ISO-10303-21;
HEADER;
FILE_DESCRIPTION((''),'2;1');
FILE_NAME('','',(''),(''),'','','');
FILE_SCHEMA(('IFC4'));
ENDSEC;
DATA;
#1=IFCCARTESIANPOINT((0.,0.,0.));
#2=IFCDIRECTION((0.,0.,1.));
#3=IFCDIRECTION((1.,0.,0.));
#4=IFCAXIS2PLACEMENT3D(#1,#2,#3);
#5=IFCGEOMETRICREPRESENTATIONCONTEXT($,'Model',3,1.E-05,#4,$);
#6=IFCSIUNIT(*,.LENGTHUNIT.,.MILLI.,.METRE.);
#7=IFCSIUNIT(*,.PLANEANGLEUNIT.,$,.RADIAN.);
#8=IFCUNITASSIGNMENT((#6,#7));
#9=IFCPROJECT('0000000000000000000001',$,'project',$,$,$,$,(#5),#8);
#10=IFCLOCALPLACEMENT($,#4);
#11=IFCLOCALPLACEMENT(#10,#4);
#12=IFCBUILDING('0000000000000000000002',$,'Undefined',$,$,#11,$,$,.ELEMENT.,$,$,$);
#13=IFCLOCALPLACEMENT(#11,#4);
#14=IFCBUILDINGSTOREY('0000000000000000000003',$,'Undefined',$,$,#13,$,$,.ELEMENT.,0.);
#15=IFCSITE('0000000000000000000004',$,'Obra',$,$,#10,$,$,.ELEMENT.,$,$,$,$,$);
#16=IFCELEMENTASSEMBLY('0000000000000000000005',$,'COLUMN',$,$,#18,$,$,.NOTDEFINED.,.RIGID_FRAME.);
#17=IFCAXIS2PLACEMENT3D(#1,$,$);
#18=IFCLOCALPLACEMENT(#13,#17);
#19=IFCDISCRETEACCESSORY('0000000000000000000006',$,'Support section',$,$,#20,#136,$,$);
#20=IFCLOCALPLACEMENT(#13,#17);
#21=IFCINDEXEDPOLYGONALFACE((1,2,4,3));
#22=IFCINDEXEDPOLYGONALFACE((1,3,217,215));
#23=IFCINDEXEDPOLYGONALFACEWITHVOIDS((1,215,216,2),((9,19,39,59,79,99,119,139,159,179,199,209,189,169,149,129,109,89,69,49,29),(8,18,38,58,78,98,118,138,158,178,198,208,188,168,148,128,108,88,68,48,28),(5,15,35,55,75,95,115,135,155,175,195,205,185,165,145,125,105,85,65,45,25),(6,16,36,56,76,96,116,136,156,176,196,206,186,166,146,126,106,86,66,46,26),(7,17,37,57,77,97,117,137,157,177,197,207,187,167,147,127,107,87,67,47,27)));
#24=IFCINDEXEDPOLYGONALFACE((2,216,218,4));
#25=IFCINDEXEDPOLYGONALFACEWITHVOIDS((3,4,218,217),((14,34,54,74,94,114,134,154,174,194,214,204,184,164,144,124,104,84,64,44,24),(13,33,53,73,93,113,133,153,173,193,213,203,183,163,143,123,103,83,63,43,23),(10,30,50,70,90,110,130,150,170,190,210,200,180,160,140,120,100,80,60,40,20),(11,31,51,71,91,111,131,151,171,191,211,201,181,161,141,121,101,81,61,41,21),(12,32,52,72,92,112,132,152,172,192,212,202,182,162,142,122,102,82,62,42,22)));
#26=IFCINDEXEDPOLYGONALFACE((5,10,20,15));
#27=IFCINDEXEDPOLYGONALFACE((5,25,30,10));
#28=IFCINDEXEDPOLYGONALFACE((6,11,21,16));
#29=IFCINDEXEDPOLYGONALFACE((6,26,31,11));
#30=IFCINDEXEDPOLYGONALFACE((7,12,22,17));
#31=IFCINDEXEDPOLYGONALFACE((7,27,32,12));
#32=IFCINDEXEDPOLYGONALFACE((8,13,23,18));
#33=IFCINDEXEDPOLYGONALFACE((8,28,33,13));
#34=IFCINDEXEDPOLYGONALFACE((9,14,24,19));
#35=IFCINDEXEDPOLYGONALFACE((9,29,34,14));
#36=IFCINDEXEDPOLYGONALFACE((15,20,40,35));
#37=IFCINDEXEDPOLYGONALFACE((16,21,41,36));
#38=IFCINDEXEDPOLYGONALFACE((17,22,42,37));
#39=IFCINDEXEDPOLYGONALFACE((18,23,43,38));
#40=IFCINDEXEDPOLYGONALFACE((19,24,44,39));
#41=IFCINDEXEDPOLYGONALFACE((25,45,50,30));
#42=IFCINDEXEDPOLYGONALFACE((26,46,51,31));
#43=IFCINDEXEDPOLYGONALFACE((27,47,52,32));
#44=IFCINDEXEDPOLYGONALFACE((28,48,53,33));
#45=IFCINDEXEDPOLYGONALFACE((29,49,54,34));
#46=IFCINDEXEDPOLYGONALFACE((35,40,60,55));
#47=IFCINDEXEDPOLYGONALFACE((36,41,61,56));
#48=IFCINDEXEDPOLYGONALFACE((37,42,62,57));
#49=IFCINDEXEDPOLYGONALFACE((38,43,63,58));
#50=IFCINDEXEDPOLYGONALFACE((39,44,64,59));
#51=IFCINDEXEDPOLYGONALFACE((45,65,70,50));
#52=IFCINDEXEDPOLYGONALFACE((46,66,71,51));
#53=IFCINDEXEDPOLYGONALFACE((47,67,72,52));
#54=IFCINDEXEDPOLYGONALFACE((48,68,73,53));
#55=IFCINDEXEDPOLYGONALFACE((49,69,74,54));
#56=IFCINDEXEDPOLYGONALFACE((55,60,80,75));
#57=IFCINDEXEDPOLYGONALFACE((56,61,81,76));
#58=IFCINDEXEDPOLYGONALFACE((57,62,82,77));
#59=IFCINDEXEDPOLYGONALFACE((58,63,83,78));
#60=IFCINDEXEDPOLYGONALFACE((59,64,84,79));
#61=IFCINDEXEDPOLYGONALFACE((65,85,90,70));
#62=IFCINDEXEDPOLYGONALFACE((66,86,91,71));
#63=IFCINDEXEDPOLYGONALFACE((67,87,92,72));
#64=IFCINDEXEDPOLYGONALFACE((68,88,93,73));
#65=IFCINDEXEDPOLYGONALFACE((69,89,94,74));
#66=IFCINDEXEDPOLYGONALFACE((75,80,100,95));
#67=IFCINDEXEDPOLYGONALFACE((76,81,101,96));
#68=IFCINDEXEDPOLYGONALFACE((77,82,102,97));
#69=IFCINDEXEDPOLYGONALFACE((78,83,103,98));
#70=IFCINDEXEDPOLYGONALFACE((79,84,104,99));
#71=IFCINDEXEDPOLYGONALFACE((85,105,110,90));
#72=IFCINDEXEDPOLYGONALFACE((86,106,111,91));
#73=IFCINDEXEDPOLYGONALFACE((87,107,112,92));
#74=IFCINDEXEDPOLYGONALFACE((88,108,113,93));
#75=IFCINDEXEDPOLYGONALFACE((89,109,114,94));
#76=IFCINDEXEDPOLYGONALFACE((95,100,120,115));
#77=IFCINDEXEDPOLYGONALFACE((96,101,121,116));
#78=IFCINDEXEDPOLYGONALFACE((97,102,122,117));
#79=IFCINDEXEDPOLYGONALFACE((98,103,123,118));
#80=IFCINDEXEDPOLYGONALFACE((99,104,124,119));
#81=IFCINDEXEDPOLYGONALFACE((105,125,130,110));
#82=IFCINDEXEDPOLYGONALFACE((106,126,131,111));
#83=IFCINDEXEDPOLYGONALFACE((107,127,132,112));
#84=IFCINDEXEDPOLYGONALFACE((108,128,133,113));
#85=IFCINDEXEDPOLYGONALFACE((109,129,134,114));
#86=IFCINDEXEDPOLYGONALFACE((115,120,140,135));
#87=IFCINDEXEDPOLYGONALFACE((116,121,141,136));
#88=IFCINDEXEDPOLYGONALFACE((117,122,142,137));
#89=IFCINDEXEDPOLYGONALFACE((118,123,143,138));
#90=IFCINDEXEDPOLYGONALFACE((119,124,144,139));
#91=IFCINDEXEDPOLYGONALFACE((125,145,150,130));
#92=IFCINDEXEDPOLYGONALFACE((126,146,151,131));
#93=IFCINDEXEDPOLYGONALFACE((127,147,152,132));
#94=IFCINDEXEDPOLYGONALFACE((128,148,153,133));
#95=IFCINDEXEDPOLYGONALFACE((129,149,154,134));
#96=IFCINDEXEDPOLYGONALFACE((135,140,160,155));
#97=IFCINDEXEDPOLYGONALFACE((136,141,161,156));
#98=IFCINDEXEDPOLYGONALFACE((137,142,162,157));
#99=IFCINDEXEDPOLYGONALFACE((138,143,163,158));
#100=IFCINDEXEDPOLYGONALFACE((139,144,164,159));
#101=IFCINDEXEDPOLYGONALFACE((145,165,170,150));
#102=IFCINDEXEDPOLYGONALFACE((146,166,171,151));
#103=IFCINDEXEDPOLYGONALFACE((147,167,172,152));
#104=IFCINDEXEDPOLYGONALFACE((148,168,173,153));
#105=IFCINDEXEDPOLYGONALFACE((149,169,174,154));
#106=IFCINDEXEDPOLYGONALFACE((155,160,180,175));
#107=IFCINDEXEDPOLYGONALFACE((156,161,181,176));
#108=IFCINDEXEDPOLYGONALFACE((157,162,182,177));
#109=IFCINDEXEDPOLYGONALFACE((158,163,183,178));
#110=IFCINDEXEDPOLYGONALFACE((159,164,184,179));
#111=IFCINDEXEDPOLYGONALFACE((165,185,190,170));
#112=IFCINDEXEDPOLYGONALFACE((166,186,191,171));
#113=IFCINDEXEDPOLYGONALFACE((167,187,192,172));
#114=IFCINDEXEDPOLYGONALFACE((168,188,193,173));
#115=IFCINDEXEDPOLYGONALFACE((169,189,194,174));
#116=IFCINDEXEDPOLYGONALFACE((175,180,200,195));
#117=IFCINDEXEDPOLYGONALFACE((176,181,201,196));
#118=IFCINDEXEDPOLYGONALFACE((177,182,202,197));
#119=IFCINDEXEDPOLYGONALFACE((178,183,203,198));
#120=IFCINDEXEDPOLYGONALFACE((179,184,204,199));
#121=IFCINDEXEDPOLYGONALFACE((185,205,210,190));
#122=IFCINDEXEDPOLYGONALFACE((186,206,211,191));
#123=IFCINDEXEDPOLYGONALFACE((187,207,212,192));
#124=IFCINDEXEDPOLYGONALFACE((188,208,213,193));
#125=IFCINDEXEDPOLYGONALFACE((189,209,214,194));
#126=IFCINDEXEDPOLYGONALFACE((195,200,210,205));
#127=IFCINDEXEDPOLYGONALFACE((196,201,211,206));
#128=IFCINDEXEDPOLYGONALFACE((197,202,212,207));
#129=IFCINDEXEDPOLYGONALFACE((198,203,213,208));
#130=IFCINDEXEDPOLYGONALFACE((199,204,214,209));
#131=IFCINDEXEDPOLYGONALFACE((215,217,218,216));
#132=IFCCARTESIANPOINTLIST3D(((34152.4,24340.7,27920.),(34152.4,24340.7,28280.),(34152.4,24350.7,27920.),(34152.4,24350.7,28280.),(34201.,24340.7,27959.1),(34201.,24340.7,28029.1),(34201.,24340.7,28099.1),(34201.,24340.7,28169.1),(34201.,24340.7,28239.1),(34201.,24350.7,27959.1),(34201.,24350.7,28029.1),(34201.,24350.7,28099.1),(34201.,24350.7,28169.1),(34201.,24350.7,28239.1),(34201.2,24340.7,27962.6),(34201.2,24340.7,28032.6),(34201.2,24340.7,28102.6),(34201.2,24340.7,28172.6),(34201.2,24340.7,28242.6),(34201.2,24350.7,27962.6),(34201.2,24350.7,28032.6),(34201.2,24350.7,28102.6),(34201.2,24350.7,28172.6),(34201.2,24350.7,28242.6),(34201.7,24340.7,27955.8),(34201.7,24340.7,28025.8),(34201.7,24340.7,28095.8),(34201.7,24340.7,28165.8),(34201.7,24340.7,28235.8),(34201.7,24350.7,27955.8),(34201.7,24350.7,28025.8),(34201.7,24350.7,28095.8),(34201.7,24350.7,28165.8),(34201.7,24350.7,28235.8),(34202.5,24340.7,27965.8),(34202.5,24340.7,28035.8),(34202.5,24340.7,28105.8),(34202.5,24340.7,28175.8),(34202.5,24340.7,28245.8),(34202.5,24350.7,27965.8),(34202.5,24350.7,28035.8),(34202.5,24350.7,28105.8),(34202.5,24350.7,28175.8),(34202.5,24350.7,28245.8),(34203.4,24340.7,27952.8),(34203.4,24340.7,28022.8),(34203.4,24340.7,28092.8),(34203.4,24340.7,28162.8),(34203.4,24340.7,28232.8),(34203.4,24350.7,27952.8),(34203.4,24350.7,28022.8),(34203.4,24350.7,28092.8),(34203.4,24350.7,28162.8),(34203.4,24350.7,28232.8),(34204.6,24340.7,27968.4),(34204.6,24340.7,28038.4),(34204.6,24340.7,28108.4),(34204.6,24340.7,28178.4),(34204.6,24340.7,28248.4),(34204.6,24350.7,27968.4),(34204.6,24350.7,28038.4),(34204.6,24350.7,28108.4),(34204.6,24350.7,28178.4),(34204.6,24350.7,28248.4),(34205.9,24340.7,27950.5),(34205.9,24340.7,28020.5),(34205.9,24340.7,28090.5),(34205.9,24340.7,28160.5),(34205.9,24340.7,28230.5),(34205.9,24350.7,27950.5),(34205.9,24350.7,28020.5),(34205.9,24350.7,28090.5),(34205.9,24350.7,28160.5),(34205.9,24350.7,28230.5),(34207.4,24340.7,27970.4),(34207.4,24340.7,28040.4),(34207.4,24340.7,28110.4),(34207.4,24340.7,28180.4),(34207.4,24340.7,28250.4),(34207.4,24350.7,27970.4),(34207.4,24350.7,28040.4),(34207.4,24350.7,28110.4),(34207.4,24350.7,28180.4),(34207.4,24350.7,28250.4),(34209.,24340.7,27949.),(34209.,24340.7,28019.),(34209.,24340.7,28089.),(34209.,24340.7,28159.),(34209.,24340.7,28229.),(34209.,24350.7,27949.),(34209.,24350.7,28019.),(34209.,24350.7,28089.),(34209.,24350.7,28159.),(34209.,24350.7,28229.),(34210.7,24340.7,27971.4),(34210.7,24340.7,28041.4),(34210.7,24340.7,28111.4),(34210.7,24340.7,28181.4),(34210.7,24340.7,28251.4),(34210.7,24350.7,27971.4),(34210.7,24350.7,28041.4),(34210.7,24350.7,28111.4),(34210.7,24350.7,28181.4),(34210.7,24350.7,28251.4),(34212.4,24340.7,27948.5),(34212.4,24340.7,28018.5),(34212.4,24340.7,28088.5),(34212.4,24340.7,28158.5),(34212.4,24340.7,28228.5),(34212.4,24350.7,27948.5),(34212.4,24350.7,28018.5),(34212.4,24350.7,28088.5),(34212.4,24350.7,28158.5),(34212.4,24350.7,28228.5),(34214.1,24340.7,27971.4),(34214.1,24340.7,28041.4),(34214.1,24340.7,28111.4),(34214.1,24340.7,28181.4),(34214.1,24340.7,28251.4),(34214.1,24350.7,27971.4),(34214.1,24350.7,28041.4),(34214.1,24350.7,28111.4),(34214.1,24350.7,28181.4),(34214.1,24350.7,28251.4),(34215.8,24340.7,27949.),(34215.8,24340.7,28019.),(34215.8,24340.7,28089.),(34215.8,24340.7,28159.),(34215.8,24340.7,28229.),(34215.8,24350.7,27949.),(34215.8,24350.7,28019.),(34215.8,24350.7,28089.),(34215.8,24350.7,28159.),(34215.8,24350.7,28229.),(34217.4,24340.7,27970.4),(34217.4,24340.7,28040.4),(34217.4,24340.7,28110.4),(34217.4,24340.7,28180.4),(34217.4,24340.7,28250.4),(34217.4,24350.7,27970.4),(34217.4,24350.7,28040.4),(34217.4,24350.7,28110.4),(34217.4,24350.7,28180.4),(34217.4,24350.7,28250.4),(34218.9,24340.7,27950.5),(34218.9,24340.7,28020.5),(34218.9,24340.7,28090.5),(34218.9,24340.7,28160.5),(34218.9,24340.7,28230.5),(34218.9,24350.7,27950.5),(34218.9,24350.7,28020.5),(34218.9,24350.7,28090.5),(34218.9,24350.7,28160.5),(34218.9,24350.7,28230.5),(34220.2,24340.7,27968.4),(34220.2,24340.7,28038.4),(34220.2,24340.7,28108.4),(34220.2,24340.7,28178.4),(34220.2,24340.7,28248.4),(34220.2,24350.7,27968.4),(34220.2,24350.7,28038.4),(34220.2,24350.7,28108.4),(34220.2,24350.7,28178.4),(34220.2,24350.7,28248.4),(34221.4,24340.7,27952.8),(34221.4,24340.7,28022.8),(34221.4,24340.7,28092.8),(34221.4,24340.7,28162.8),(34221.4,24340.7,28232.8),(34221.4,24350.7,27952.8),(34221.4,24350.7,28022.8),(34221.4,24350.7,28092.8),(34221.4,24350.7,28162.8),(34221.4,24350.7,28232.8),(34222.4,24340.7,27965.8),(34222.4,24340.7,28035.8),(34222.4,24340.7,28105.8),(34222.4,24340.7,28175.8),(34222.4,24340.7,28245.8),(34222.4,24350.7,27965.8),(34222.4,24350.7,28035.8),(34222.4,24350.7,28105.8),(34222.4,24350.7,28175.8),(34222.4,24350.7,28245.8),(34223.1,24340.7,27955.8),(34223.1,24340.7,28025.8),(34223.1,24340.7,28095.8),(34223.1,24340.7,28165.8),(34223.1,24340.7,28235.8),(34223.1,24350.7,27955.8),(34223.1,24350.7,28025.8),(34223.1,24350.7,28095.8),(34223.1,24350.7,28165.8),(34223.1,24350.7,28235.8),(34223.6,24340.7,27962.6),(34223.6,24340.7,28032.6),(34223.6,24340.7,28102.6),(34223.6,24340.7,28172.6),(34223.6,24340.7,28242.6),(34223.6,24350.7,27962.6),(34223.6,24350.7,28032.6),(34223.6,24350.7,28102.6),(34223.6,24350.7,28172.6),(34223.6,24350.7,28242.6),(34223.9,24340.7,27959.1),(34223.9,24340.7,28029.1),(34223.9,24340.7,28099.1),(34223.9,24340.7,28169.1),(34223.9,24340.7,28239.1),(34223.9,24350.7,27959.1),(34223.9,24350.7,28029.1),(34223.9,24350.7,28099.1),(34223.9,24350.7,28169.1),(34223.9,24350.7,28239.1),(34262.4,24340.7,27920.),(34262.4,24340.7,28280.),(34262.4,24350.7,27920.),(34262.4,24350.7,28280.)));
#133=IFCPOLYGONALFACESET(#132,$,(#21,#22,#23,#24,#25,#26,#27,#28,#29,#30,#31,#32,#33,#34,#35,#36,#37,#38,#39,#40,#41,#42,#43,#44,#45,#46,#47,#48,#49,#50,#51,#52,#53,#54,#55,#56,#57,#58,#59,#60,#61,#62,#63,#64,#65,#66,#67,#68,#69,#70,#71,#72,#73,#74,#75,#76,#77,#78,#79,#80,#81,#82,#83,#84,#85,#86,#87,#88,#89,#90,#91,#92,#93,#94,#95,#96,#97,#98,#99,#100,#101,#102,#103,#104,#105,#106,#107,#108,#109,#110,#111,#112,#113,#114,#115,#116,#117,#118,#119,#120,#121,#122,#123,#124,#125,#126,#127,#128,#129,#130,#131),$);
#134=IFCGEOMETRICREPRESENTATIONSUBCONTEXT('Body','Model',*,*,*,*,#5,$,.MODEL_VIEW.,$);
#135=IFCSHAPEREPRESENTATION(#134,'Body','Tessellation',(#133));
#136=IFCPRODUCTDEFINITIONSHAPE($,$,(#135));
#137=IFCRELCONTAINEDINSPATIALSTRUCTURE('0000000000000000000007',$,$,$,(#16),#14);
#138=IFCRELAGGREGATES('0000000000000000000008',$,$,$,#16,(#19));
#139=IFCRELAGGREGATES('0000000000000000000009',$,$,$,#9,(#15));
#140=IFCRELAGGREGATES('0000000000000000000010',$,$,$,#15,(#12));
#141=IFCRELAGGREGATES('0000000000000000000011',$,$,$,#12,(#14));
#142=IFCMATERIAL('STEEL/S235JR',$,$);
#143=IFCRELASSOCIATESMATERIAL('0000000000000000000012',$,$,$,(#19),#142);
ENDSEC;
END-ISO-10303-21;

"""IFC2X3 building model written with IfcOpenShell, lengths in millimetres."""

from ifc_helpers import new_model, si_unit, frame, origin_with_axes, origin_2d_with_axis, place, context, subcontext, project, spatial, rectangle, circle, extrude, source, transform, mapped, material, element, aggregate, save


model = new_model("IFC2X3")

# Units and contexts
model_context = context("Model", 3, precision=1e-05, world=origin_with_axes())
body_context = subcontext(model_context, "Body", "Model", "MODEL_VIEW")
ifc_project = project(units=[si_unit("LENGTHUNIT", "METRE", prefix="MILLI"), si_unit("PLANEANGLEUNIT", "RADIAN")], contexts=[model_context])

# Site, building, storey
site_placement = place(None, origin_with_axes())
site = spatial("IfcSite", under=ifc_project, at=site_placement, Name="Obra", CompositionType="ELEMENT")
building_placement = place(site_placement, origin_with_axes())
building = spatial("IfcBuilding", under=site, at=building_placement, Name="Undefined", CompositionType="ELEMENT")
storey_placement = place(building_placement, origin_with_axes())
storey = spatial("IfcBuildingStorey", under=building, at=storey_placement, Name="Undefined", CompositionType="ELEMENT", Elevation=0.0)

# Shared definitions
ifc_material_1 = material(Name="STEEL/S235JR")

# Shared definitions
shared_shape_1 = source(origin_with_axes(), body_context, "Body", "SweptSolid", [
    extrude(circle(Radius=11.5, at=origin_2d_with_axis()), frame((0.0, -14.4, 0.0), z_axis=(0.0, 1.0, 0.0), x_axis=(1.0, 0.0, 0.0)), (0.0, 0.0, 1.0), 10.2),
])

# Element assembly, discrete accessory, opening
assembly_1_placement = place(storey_placement, origin_with_axes())
assembly_1 = element("IfcElementAssembly", 1, at=assembly_1_placement, inside=storey, Name="COLUMN", AssemblyPlace="NOTDEFINED", PredefinedType="RIGID_FRAME")
discrete_accessory_1_placement = place(assembly_1_placement, frame((34207.4, 24345.7, 27920.0), z_axis=(0.0, 0.0, 1.0), x_axis=(-1.0, 0.0, 0.0)))
discrete_accessory_1 = element("IfcDiscreteAccessory", 2, at=discrete_accessory_1_placement, material=ifc_material_1, Name="Support section", context=body_context, shape_type="SweptSolid", body=[
    extrude(rectangle(XDim=10.0, YDim=110.0, at=origin_2d_with_axis()), frame((0.0, 0.0, 360.0), z_axis=(0.0, 0.0, -1.0), x_axis=(0.0, 1.0, 0.0)), (0.0, 0.0, 1.0), 360.0),
])
opening_1_placement = place(assembly_1_placement, frame((34162.4, 24355.0, 28300.0), z_axis=(1.0, 0.0, 0.0), x_axis=(0.0, 0.0, -1.0)))
element("IfcOpeningElement", 3, at=opening_1_placement, cuts=discrete_accessory_1, ObjectType="Opening", context=body_context, shape_type="MappedRepresentation", body=[
    mapped(shared_shape_1, transform((60.0, 0.0, 50.0))),
    mapped(shared_shape_1, transform((130.0, 0.0, 50.0))),
    mapped(shared_shape_1, transform((200.0, 0.0, 50.0))),
    mapped(shared_shape_1, transform((270.0, 0.0, 50.0))),
    mapped(shared_shape_1, transform((340.0, 0.0, 50.0))),
])
aggregate(assembly_1, [discrete_accessory_1])

save(model, "model.ifc")
